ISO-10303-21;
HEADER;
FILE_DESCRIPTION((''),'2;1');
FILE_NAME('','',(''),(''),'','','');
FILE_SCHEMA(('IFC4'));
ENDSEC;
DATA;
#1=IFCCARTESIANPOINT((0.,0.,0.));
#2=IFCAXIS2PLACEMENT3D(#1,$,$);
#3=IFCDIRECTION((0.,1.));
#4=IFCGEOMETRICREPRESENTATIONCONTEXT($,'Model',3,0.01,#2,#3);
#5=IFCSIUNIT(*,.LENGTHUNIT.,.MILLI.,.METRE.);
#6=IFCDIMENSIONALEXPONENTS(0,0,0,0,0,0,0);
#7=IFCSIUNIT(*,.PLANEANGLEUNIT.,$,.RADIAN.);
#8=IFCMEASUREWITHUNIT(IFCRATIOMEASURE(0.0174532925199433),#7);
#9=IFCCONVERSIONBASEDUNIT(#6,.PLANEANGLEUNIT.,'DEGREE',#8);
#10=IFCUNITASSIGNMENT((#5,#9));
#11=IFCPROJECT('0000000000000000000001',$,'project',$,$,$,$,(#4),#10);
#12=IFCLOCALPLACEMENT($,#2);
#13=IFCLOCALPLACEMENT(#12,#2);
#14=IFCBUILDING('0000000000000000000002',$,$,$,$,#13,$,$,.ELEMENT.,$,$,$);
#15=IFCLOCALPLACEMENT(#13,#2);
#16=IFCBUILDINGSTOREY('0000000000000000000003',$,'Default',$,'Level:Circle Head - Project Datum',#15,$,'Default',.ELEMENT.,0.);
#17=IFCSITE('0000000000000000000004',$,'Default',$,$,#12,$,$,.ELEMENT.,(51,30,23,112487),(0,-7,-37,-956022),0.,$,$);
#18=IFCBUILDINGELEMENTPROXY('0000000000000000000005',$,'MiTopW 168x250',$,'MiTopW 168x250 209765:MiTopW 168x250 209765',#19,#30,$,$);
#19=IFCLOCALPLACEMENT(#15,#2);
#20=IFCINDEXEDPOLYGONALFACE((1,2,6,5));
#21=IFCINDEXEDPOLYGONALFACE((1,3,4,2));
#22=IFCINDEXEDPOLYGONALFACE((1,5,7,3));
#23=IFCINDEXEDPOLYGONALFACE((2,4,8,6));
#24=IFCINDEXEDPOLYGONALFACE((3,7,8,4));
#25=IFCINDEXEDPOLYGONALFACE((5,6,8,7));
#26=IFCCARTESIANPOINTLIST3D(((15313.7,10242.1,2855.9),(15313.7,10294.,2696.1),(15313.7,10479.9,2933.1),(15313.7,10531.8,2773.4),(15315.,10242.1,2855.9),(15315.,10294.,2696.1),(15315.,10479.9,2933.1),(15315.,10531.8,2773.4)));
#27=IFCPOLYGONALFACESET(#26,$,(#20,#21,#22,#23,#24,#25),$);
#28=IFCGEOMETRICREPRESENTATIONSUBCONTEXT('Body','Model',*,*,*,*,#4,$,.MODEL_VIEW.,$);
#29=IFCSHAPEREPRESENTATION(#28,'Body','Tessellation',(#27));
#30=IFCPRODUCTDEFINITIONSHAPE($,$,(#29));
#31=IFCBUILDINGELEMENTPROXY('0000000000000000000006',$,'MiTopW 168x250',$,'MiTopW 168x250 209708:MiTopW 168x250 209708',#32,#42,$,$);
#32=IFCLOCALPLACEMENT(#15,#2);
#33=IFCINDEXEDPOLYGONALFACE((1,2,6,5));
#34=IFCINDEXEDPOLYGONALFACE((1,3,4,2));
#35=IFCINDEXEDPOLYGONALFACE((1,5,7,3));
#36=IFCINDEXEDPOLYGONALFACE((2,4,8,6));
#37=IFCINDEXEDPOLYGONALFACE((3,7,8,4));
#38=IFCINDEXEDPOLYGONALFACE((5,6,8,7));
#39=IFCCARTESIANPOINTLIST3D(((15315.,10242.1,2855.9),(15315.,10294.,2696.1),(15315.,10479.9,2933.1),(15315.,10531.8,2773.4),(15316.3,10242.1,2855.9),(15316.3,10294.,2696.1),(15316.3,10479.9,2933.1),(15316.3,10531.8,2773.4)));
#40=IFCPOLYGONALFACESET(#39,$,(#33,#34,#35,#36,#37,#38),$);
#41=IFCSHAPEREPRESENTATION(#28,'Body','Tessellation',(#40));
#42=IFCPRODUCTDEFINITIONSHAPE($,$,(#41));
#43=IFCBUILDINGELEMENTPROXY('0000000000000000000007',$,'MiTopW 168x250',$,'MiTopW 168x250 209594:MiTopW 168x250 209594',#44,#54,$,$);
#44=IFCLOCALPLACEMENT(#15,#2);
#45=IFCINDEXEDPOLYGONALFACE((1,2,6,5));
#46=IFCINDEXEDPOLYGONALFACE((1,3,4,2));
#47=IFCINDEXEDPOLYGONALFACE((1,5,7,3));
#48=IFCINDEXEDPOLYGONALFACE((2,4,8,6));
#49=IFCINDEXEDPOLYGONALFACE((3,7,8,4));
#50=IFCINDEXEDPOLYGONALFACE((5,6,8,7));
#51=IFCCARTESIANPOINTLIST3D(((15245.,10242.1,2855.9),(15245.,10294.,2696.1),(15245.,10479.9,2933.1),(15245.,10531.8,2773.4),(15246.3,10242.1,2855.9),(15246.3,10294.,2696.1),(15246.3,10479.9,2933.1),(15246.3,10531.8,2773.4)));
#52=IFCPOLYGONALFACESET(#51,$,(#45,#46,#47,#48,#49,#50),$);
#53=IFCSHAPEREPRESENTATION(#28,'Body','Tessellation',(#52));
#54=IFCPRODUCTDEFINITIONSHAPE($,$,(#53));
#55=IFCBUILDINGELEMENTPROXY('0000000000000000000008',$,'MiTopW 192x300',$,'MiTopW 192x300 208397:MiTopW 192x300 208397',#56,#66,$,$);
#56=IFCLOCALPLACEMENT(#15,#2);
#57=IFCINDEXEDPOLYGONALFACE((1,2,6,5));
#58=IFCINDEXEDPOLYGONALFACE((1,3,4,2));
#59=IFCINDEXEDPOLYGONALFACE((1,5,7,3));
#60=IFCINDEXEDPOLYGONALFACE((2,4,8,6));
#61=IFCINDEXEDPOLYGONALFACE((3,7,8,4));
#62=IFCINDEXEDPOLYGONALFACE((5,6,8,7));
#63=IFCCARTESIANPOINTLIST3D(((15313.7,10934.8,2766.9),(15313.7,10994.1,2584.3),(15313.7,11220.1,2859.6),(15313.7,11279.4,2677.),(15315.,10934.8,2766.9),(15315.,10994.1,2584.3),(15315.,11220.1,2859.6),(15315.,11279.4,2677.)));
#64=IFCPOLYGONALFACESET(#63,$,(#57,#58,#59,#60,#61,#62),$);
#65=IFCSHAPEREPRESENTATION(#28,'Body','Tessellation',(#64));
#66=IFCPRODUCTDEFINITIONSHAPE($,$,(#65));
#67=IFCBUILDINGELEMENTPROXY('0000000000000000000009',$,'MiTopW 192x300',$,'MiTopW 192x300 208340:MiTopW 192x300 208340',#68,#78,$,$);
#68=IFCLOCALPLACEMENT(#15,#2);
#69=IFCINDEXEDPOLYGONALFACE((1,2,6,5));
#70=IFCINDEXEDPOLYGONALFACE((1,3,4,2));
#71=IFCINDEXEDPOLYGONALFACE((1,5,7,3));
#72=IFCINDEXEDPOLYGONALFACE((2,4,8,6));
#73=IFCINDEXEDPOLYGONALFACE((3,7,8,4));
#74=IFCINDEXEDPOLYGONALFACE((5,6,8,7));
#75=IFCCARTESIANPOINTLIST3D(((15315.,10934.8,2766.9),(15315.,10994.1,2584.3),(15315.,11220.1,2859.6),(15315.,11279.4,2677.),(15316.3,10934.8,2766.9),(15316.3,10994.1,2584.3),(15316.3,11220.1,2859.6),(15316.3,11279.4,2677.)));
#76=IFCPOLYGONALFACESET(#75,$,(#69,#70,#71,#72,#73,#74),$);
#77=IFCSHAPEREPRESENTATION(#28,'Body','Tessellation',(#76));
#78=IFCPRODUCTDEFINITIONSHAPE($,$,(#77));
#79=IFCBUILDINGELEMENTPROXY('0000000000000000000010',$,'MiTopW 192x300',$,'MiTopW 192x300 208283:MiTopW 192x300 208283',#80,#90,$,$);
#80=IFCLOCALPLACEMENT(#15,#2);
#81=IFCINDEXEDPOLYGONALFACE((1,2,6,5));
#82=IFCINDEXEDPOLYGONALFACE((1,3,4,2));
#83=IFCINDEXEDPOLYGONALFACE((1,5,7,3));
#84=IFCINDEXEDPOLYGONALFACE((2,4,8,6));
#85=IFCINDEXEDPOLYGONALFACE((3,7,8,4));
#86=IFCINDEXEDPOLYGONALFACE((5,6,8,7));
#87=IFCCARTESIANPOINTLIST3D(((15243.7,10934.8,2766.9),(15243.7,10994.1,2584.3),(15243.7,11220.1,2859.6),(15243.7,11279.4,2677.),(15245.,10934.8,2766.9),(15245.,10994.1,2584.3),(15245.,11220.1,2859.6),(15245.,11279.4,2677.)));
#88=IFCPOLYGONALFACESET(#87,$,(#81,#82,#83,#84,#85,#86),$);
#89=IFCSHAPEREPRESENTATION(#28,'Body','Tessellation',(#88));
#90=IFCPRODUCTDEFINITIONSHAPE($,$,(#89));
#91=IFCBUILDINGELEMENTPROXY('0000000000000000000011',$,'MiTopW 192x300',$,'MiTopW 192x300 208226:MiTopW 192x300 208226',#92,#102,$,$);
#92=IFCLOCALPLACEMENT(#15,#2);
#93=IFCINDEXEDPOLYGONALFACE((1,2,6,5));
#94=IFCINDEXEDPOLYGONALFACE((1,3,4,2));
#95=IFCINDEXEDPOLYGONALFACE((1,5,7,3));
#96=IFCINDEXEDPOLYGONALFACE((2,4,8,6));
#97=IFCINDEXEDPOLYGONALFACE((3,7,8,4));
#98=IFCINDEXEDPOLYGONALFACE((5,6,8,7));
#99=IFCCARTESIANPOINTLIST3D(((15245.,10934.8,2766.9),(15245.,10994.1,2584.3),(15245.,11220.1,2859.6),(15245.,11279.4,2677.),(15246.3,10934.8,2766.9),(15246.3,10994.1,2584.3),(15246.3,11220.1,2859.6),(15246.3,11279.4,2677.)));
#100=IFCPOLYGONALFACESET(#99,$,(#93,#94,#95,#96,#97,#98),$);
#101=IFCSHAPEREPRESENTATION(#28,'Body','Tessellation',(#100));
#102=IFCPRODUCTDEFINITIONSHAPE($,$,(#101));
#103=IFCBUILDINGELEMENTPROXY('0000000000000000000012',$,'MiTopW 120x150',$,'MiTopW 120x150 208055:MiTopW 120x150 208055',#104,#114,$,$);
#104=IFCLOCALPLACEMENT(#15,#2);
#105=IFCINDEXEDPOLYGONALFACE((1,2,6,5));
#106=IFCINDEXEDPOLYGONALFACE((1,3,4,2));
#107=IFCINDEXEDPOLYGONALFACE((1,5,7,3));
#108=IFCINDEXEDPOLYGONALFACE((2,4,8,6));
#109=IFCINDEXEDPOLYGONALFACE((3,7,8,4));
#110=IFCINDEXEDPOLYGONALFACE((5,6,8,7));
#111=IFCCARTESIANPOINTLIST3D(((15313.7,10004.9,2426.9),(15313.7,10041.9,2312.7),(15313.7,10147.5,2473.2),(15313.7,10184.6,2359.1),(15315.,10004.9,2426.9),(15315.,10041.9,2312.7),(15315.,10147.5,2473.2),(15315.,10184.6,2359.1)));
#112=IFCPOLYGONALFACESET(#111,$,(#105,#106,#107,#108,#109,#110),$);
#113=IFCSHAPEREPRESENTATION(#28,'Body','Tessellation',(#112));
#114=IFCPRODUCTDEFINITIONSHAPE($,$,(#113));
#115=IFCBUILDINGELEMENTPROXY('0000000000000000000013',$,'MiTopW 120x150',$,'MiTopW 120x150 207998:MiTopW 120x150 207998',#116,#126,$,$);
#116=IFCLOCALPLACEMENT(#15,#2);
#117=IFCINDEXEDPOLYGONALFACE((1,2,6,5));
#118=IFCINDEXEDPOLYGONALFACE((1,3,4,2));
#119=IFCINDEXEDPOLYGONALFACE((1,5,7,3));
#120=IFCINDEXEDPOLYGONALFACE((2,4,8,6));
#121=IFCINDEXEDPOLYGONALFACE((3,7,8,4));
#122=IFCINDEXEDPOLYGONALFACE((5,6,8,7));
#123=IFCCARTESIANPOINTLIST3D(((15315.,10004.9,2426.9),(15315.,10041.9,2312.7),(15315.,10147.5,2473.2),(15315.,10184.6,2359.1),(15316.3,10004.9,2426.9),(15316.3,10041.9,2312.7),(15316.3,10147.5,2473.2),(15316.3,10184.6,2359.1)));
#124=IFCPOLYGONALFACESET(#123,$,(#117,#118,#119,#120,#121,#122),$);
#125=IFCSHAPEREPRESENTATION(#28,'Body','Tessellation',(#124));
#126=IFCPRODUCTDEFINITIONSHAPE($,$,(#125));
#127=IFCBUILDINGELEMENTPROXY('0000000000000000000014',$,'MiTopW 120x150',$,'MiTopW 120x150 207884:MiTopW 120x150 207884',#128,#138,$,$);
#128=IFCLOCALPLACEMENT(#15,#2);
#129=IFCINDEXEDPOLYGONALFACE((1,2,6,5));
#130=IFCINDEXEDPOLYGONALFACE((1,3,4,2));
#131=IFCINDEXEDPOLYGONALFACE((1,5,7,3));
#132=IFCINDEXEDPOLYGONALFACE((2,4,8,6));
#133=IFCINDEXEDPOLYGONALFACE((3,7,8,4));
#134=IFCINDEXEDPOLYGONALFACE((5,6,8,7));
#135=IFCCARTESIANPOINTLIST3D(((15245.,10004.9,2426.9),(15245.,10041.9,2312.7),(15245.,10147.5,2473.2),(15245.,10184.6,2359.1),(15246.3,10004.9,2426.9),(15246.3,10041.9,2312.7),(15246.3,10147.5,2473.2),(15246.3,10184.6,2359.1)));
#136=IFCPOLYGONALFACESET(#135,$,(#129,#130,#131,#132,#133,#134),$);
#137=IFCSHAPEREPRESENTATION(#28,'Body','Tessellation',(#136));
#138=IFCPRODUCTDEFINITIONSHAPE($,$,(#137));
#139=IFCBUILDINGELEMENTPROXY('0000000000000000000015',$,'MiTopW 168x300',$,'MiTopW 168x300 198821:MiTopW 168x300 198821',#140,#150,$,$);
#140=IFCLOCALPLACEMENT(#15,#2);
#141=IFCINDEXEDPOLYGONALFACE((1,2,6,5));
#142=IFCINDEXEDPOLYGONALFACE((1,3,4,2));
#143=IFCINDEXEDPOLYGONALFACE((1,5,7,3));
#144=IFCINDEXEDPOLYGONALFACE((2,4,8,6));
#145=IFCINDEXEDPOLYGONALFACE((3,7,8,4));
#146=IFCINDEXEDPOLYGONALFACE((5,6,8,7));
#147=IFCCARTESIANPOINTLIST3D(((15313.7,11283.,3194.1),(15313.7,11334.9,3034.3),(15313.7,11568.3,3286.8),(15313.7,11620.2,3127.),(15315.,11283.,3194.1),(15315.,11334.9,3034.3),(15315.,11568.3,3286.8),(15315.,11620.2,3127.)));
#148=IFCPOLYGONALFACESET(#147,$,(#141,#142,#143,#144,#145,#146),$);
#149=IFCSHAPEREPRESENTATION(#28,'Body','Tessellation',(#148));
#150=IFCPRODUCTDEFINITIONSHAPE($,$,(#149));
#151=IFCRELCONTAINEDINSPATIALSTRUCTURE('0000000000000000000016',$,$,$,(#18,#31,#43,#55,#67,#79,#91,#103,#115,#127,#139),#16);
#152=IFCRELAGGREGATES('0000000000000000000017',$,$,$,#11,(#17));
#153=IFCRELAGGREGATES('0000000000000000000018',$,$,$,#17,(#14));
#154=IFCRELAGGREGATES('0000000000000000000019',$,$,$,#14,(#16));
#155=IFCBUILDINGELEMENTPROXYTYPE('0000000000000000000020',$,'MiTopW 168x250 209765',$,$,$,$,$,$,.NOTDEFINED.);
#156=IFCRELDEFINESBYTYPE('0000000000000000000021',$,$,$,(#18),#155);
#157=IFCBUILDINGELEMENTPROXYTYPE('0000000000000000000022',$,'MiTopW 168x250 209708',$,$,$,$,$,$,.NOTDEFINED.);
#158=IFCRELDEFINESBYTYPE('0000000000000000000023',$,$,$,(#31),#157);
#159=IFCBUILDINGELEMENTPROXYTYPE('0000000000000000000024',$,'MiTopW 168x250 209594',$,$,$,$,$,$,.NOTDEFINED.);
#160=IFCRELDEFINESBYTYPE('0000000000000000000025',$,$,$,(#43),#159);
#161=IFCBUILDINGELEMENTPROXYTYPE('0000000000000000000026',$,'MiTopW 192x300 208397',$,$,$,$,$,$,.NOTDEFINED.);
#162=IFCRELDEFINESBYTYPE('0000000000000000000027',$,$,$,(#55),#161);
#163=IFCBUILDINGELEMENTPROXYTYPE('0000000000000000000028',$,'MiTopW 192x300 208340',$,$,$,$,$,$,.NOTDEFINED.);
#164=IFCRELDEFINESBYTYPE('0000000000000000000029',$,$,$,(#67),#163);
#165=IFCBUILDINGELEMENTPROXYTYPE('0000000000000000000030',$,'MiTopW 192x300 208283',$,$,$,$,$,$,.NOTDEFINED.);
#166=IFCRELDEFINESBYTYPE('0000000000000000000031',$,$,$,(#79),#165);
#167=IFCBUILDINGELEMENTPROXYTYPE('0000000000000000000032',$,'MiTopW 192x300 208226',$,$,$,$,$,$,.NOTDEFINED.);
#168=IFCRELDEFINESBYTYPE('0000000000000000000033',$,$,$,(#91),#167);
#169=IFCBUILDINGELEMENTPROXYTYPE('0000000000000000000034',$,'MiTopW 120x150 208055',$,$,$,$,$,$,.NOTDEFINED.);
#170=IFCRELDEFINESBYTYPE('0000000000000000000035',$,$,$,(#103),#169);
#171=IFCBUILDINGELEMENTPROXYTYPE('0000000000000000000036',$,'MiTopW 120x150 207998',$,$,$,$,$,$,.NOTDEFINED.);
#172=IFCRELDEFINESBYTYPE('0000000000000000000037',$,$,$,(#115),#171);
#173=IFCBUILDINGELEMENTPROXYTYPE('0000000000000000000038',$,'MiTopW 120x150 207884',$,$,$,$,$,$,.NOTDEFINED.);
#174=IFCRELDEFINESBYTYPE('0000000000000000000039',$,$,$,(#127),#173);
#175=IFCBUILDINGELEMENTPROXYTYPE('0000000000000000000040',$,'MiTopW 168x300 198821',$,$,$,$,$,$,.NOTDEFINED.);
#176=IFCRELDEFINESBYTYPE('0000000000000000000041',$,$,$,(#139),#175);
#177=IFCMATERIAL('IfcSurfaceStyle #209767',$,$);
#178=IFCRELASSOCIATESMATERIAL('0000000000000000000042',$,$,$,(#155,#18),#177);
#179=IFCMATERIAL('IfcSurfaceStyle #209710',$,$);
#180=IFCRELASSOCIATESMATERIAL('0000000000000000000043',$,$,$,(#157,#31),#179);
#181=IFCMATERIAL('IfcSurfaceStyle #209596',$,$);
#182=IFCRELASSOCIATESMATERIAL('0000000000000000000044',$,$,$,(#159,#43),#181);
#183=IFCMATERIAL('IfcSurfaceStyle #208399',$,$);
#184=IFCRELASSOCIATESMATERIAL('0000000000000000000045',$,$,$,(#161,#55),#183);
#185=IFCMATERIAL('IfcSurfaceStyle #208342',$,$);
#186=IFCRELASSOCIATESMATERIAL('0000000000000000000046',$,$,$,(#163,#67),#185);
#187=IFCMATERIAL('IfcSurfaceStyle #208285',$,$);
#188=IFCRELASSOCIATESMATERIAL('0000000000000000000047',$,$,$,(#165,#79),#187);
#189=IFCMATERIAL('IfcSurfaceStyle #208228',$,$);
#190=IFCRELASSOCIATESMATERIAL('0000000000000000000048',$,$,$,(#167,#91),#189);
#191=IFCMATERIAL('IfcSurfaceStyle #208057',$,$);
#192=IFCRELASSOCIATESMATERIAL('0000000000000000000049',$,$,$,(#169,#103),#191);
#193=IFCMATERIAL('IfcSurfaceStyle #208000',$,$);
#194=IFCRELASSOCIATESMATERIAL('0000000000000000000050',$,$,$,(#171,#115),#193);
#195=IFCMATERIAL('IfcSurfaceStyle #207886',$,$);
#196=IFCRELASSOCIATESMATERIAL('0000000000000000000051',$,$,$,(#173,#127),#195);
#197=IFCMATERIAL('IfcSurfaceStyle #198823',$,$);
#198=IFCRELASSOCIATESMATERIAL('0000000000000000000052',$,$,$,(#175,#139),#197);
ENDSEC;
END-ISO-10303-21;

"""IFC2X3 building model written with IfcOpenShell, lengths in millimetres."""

from ifc_helpers import new_model, entity, si_unit, converted_unit, direction, frame, origin, place, context, subcontext, project, spatial, polyline, outline, extrude, source, transform, mapped, material, type_object, type_shapes, element, save


model = new_model("IFC2X3")

# Units and contexts
model_context = context("Model", 3, precision=0.01, world=origin(), true_north=direction((0.0, 1.0)))
body_context = subcontext(model_context, "Body", "Model", "MODEL_VIEW")
ifc_project = project(units=[si_unit("LENGTHUNIT", "METRE", prefix="MILLI"), converted_unit("PLANEANGLEUNIT", "DEGREE", entity("IfcRatioMeasure", 0.0174532925199433), si_unit("PLANEANGLEUNIT", "RADIAN"), dimensions=[0, 0, 0, 0, 0, 0, 0])], contexts=[model_context])

# Site, building, storey
site_placement = place(None, origin())
site = spatial("IfcSite", under=ifc_project, at=site_placement, Name="Default", CompositionType="ELEMENT", RefLatitude=(51, 30, 23, 112487), RefLongitude=(0, -7, -37, -956022), RefElevation=0.0)
building_placement = place(site_placement, origin())
building = spatial("IfcBuilding", under=site, at=building_placement, CompositionType="ELEMENT")
storey_placement = place(building_placement, origin())
storey = spatial("IfcBuildingStorey", under=building, at=storey_placement, Name="Default", ObjectType="Level:Circle Head - Project Datum", LongName="Default", CompositionType="ELEMENT", Elevation=0.0)

# Building element proxies
ifc_material_1 = material(Name="IfcSurfaceStyle #209767")
building_element_proxy_type_1 = type_object("IfcBuildingElementProxyType", Name="MiTopW 168x250 209765", PredefinedType="NOTDEFINED", material=ifc_material_1)
shared_shape_1 = source(origin(), body_context, "Body", "SweptSolid", [
    extrude(outline(polyline([(-125.0, -84.0), (125.0, -84.0), (125.0, 84.0), (-125.0, 84.0), (-125.0, -84.0)])), frame((125.0, 84.0, 0.0), z_axis=(0.0, 0.0, 1.0), x_axis=(-1.0, 0.0, 0.0)), (0.0, 0.0, 1.0), 1.3),
])
type_shapes(building_element_proxy_type_1, [shared_shape_1])
proxy_1_placement = place(building_placement, frame((15315.0, 10242.1, 2855.9), z_axis=(-1.0, 0.0, 0.0), x_axis=(0.0, 0.951057, 0.309017)))
element("IfcBuildingElementProxy", 1, at=proxy_1_placement, inside=storey, type_object=building_element_proxy_type_1, material=ifc_material_1, Name="MiTopW 168x250", ObjectType="MiTopW 168x250 209765:MiTopW 168x250 209765", context=body_context, shape_type="MappedRepresentation", body=[
    mapped(shared_shape_1, transform((0.0, 0.0, 0.0), scale=1.0)),
])
ifc_material_2 = material(Name="IfcSurfaceStyle #209710")
building_element_proxy_type_2 = type_object("IfcBuildingElementProxyType", Name="MiTopW 168x250 209708", PredefinedType="NOTDEFINED", material=ifc_material_2)
shared_shape_2 = source(origin(), body_context, "Body", "SweptSolid", [
    extrude(outline(polyline([(-125.0, -84.0), (125.0, -84.0), (125.0, 84.0), (-125.0, 84.0), (-125.0, -84.0)])), frame((125.0, 84.0, 0.0), z_axis=(0.0, 0.0, 1.0), x_axis=(-1.0, 0.0, 0.0)), (0.0, 0.0, 1.0), 1.3),
])
type_shapes(building_element_proxy_type_2, [shared_shape_2])
proxy_2_placement = place(building_placement, frame((15316.3, 10242.1, 2855.9), z_axis=(-1.0, 0.0, 0.0), x_axis=(0.0, 0.951057, 0.309017)))
element("IfcBuildingElementProxy", 2, at=proxy_2_placement, inside=storey, type_object=building_element_proxy_type_2, material=ifc_material_2, Name="MiTopW 168x250", ObjectType="MiTopW 168x250 209708:MiTopW 168x250 209708", context=body_context, shape_type="MappedRepresentation", body=[
    mapped(shared_shape_2, transform((0.0, 0.0, 0.0), scale=1.0)),
])
ifc_material_3 = material(Name="IfcSurfaceStyle #209596")
building_element_proxy_type_3 = type_object("IfcBuildingElementProxyType", Name="MiTopW 168x250 209594", PredefinedType="NOTDEFINED", material=ifc_material_3)
shared_shape_3 = source(origin(), body_context, "Body", "SweptSolid", [
    extrude(outline(polyline([(-125.0, -84.0), (125.0, -84.0), (125.0, 84.0), (-125.0, 84.0), (-125.0, -84.0)])), frame((125.0, 84.0, 0.0), z_axis=(0.0, 0.0, 1.0), x_axis=(-1.0, 0.0, 0.0)), (0.0, 0.0, 1.0), 1.3),
])
type_shapes(building_element_proxy_type_3, [shared_shape_3])
proxy_3_placement = place(building_placement, frame((15246.3, 10242.1, 2855.9), z_axis=(-1.0, 0.0, 0.0), x_axis=(0.0, 0.951057, 0.309017)))
element("IfcBuildingElementProxy", 3, at=proxy_3_placement, inside=storey, type_object=building_element_proxy_type_3, material=ifc_material_3, Name="MiTopW 168x250", ObjectType="MiTopW 168x250 209594:MiTopW 168x250 209594", context=body_context, shape_type="MappedRepresentation", body=[
    mapped(shared_shape_3, transform((0.0, 0.0, 0.0), scale=1.0)),
])
ifc_material_4 = material(Name="IfcSurfaceStyle #208399")
building_element_proxy_type_4 = type_object("IfcBuildingElementProxyType", Name="MiTopW 192x300 208397", PredefinedType="NOTDEFINED", material=ifc_material_4)
shared_shape_4 = source(origin(), body_context, "Body", "SweptSolid", [
    extrude(outline(polyline([(-150.0, -96.0), (150.0, -96.0), (150.0, 96.0), (-150.0, 96.0), (-150.0, -96.0)])), frame((150.0, 96.0, 0.0), z_axis=(0.0, 0.0, 1.0), x_axis=(-1.0, 0.0, 0.0)), (0.0, 0.0, 1.0), 1.3),
])
type_shapes(building_element_proxy_type_4, [shared_shape_4])
proxy_4_placement = place(building_placement, frame((15315.0, 10934.8, 2766.9), z_axis=(-1.0, 0.0, 0.0), x_axis=(0.0, 0.951057, 0.309017)))
element("IfcBuildingElementProxy", 4, at=proxy_4_placement, inside=storey, type_object=building_element_proxy_type_4, material=ifc_material_4, Name="MiTopW 192x300", ObjectType="MiTopW 192x300 208397:MiTopW 192x300 208397", context=body_context, shape_type="MappedRepresentation", body=[
    mapped(shared_shape_4, transform((0.0, 0.0, 0.0), scale=1.0)),
])
ifc_material_5 = material(Name="IfcSurfaceStyle #208342")
building_element_proxy_type_5 = type_object("IfcBuildingElementProxyType", Name="MiTopW 192x300 208340", PredefinedType="NOTDEFINED", material=ifc_material_5)
shared_shape_5 = source(origin(), body_context, "Body", "SweptSolid", [
    extrude(outline(polyline([(-150.0, -96.0), (150.0, -96.0), (150.0, 96.0), (-150.0, 96.0), (-150.0, -96.0)])), frame((150.0, 96.0, 0.0), z_axis=(0.0, 0.0, 1.0), x_axis=(-1.0, 0.0, 0.0)), (0.0, 0.0, 1.0), 1.3),
])
type_shapes(building_element_proxy_type_5, [shared_shape_5])
proxy_5_placement = place(building_placement, frame((15316.3, 10934.8, 2766.9), z_axis=(-1.0, 0.0, 0.0), x_axis=(0.0, 0.951057, 0.309017)))
element("IfcBuildingElementProxy", 5, at=proxy_5_placement, inside=storey, type_object=building_element_proxy_type_5, material=ifc_material_5, Name="MiTopW 192x300", ObjectType="MiTopW 192x300 208340:MiTopW 192x300 208340", context=body_context, shape_type="MappedRepresentation", body=[
    mapped(shared_shape_5, transform((0.0, 0.0, 0.0), scale=1.0)),
])
ifc_material_6 = material(Name="IfcSurfaceStyle #208285")
building_element_proxy_type_6 = type_object("IfcBuildingElementProxyType", Name="MiTopW 192x300 208283", PredefinedType="NOTDEFINED", material=ifc_material_6)
shared_shape_6 = source(origin(), body_context, "Body", "SweptSolid", [
    extrude(outline(polyline([(-150.0, -96.0), (150.0, -96.0), (150.0, 96.0), (-150.0, 96.0), (-150.0, -96.0)])), frame((150.0, 96.0, 0.0), z_axis=(0.0, 0.0, 1.0), x_axis=(-1.0, 0.0, 0.0)), (0.0, 0.0, 1.0), 1.3),
])
type_shapes(building_element_proxy_type_6, [shared_shape_6])
proxy_6_placement = place(building_placement, frame((15245.0, 10934.8, 2766.9), z_axis=(-1.0, 0.0, 0.0), x_axis=(0.0, 0.951057, 0.309017)))
element("IfcBuildingElementProxy", 6, at=proxy_6_placement, inside=storey, type_object=building_element_proxy_type_6, material=ifc_material_6, Name="MiTopW 192x300", ObjectType="MiTopW 192x300 208283:MiTopW 192x300 208283", context=body_context, shape_type="MappedRepresentation", body=[
    mapped(shared_shape_6, transform((0.0, 0.0, 0.0), scale=1.0)),
])
ifc_material_7 = material(Name="IfcSurfaceStyle #208228")
building_element_proxy_type_7 = type_object("IfcBuildingElementProxyType", Name="MiTopW 192x300 208226", PredefinedType="NOTDEFINED", material=ifc_material_7)
shared_shape_7 = source(origin(), body_context, "Body", "SweptSolid", [
    extrude(outline(polyline([(-150.0, -96.0), (150.0, -96.0), (150.0, 96.0), (-150.0, 96.0), (-150.0, -96.0)])), frame((150.0, 96.0, 0.0), z_axis=(0.0, 0.0, 1.0), x_axis=(-1.0, 0.0, 0.0)), (0.0, 0.0, 1.0), 1.3),
])
type_shapes(building_element_proxy_type_7, [shared_shape_7])
proxy_7_placement = place(building_placement, frame((15246.3, 10934.8, 2766.9), z_axis=(-1.0, 0.0, 0.0), x_axis=(0.0, 0.951057, 0.309017)))
element("IfcBuildingElementProxy", 7, at=proxy_7_placement, inside=storey, type_object=building_element_proxy_type_7, material=ifc_material_7, Name="MiTopW 192x300", ObjectType="MiTopW 192x300 208226:MiTopW 192x300 208226", context=body_context, shape_type="MappedRepresentation", body=[
    mapped(shared_shape_7, transform((0.0, 0.0, 0.0), scale=1.0)),
])
ifc_material_8 = material(Name="IfcSurfaceStyle #208057")
building_element_proxy_type_8 = type_object("IfcBuildingElementProxyType", Name="MiTopW 120x150 208055", PredefinedType="NOTDEFINED", material=ifc_material_8)
shared_shape_8 = source(origin(), body_context, "Body", "SweptSolid", [
    extrude(outline(polyline([(-75.0, -60.0), (75.0, -60.0), (75.0, 60.0), (-75.0, 60.0), (-75.0, -60.0)])), frame((75.0, 60.0, 0.0), z_axis=(0.0, 0.0, 1.0), x_axis=(-1.0, 0.0, 0.0)), (0.0, 0.0, 1.0), 1.3),
])
type_shapes(building_element_proxy_type_8, [shared_shape_8])
proxy_8_placement = place(building_placement, frame((15315.0, 10004.9, 2426.9), z_axis=(-1.0, 0.0, 0.0), x_axis=(0.0, 0.951057, 0.309017)))
element("IfcBuildingElementProxy", 8, at=proxy_8_placement, inside=storey, type_object=building_element_proxy_type_8, material=ifc_material_8, Name="MiTopW 120x150", ObjectType="MiTopW 120x150 208055:MiTopW 120x150 208055", context=body_context, shape_type="MappedRepresentation", body=[
    mapped(shared_shape_8, transform((0.0, 0.0, 0.0), scale=1.0)),
])
ifc_material_9 = material(Name="IfcSurfaceStyle #208000")
building_element_proxy_type_9 = type_object("IfcBuildingElementProxyType", Name="MiTopW 120x150 207998", PredefinedType="NOTDEFINED", material=ifc_material_9)
shared_shape_9 = source(origin(), body_context, "Body", "SweptSolid", [
    extrude(outline(polyline([(-75.0, -60.0), (75.0, -60.0), (75.0, 60.0), (-75.0, 60.0), (-75.0, -60.0)])), frame((75.0, 60.0, 0.0), z_axis=(0.0, 0.0, 1.0), x_axis=(-1.0, 0.0, 0.0)), (0.0, 0.0, 1.0), 1.3),
])
type_shapes(building_element_proxy_type_9, [shared_shape_9])
proxy_9_placement = place(building_placement, frame((15316.3, 10004.9, 2426.9), z_axis=(-1.0, 0.0, 0.0), x_axis=(0.0, 0.951057, 0.309017)))
element("IfcBuildingElementProxy", 9, at=proxy_9_placement, inside=storey, type_object=building_element_proxy_type_9, material=ifc_material_9, Name="MiTopW 120x150", ObjectType="MiTopW 120x150 207998:MiTopW 120x150 207998", context=body_context, shape_type="MappedRepresentation", body=[
    mapped(shared_shape_9, transform((0.0, 0.0, 0.0), scale=1.0)),
])
ifc_material_10 = material(Name="IfcSurfaceStyle #207886")
building_element_proxy_type_10 = type_object("IfcBuildingElementProxyType", Name="MiTopW 120x150 207884", PredefinedType="NOTDEFINED", material=ifc_material_10)
shared_shape_10 = source(origin(), body_context, "Body", "SweptSolid", [
    extrude(outline(polyline([(-75.0, -60.0), (75.0, -60.0), (75.0, 60.0), (-75.0, 60.0), (-75.0, -60.0)])), frame((75.0, 60.0, 0.0), z_axis=(0.0, 0.0, 1.0), x_axis=(-1.0, 0.0, 0.0)), (0.0, 0.0, 1.0), 1.3),
])
type_shapes(building_element_proxy_type_10, [shared_shape_10])
proxy_10_placement = place(building_placement, frame((15246.3, 10004.9, 2426.9), z_axis=(-1.0, 0.0, 0.0), x_axis=(0.0, 0.951057, 0.309017)))
element("IfcBuildingElementProxy", 10, at=proxy_10_placement, inside=storey, type_object=building_element_proxy_type_10, material=ifc_material_10, Name="MiTopW 120x150", ObjectType="MiTopW 120x150 207884:MiTopW 120x150 207884", context=body_context, shape_type="MappedRepresentation", body=[
    mapped(shared_shape_10, transform((0.0, 0.0, 0.0), scale=1.0)),
])
ifc_material_11 = material(Name="IfcSurfaceStyle #198823")
building_element_proxy_type_11 = type_object("IfcBuildingElementProxyType", Name="MiTopW 168x300 198821", PredefinedType="NOTDEFINED", material=ifc_material_11)
shared_shape_11 = source(origin(), body_context, "Body", "SweptSolid", [
    extrude(outline(polyline([(-150.0, -84.0), (150.0, -84.0), (150.0, 84.0), (-150.0, 84.0), (-150.0, -84.0)])), frame((150.0, 84.0, 0.0), z_axis=(0.0, 0.0, 1.0), x_axis=(-1.0, 0.0, 0.0)), (0.0, 0.0, 1.0), 1.3),
])
type_shapes(building_element_proxy_type_11, [shared_shape_11])
proxy_11_placement = place(building_placement, frame((15315.0, 11283.0, 3194.1), z_axis=(-1.0, 0.0, 0.0), x_axis=(0.0, 0.951057, 0.309017)))
element("IfcBuildingElementProxy", 11, at=proxy_11_placement, inside=storey, type_object=building_element_proxy_type_11, material=ifc_material_11, Name="MiTopW 168x300", ObjectType="MiTopW 168x300 198821:MiTopW 168x300 198821", context=body_context, shape_type="MappedRepresentation", body=[
    mapped(shared_shape_11, transform((0.0, 0.0, 0.0), scale=1.0)),
])

save(model, "model.ifc")
